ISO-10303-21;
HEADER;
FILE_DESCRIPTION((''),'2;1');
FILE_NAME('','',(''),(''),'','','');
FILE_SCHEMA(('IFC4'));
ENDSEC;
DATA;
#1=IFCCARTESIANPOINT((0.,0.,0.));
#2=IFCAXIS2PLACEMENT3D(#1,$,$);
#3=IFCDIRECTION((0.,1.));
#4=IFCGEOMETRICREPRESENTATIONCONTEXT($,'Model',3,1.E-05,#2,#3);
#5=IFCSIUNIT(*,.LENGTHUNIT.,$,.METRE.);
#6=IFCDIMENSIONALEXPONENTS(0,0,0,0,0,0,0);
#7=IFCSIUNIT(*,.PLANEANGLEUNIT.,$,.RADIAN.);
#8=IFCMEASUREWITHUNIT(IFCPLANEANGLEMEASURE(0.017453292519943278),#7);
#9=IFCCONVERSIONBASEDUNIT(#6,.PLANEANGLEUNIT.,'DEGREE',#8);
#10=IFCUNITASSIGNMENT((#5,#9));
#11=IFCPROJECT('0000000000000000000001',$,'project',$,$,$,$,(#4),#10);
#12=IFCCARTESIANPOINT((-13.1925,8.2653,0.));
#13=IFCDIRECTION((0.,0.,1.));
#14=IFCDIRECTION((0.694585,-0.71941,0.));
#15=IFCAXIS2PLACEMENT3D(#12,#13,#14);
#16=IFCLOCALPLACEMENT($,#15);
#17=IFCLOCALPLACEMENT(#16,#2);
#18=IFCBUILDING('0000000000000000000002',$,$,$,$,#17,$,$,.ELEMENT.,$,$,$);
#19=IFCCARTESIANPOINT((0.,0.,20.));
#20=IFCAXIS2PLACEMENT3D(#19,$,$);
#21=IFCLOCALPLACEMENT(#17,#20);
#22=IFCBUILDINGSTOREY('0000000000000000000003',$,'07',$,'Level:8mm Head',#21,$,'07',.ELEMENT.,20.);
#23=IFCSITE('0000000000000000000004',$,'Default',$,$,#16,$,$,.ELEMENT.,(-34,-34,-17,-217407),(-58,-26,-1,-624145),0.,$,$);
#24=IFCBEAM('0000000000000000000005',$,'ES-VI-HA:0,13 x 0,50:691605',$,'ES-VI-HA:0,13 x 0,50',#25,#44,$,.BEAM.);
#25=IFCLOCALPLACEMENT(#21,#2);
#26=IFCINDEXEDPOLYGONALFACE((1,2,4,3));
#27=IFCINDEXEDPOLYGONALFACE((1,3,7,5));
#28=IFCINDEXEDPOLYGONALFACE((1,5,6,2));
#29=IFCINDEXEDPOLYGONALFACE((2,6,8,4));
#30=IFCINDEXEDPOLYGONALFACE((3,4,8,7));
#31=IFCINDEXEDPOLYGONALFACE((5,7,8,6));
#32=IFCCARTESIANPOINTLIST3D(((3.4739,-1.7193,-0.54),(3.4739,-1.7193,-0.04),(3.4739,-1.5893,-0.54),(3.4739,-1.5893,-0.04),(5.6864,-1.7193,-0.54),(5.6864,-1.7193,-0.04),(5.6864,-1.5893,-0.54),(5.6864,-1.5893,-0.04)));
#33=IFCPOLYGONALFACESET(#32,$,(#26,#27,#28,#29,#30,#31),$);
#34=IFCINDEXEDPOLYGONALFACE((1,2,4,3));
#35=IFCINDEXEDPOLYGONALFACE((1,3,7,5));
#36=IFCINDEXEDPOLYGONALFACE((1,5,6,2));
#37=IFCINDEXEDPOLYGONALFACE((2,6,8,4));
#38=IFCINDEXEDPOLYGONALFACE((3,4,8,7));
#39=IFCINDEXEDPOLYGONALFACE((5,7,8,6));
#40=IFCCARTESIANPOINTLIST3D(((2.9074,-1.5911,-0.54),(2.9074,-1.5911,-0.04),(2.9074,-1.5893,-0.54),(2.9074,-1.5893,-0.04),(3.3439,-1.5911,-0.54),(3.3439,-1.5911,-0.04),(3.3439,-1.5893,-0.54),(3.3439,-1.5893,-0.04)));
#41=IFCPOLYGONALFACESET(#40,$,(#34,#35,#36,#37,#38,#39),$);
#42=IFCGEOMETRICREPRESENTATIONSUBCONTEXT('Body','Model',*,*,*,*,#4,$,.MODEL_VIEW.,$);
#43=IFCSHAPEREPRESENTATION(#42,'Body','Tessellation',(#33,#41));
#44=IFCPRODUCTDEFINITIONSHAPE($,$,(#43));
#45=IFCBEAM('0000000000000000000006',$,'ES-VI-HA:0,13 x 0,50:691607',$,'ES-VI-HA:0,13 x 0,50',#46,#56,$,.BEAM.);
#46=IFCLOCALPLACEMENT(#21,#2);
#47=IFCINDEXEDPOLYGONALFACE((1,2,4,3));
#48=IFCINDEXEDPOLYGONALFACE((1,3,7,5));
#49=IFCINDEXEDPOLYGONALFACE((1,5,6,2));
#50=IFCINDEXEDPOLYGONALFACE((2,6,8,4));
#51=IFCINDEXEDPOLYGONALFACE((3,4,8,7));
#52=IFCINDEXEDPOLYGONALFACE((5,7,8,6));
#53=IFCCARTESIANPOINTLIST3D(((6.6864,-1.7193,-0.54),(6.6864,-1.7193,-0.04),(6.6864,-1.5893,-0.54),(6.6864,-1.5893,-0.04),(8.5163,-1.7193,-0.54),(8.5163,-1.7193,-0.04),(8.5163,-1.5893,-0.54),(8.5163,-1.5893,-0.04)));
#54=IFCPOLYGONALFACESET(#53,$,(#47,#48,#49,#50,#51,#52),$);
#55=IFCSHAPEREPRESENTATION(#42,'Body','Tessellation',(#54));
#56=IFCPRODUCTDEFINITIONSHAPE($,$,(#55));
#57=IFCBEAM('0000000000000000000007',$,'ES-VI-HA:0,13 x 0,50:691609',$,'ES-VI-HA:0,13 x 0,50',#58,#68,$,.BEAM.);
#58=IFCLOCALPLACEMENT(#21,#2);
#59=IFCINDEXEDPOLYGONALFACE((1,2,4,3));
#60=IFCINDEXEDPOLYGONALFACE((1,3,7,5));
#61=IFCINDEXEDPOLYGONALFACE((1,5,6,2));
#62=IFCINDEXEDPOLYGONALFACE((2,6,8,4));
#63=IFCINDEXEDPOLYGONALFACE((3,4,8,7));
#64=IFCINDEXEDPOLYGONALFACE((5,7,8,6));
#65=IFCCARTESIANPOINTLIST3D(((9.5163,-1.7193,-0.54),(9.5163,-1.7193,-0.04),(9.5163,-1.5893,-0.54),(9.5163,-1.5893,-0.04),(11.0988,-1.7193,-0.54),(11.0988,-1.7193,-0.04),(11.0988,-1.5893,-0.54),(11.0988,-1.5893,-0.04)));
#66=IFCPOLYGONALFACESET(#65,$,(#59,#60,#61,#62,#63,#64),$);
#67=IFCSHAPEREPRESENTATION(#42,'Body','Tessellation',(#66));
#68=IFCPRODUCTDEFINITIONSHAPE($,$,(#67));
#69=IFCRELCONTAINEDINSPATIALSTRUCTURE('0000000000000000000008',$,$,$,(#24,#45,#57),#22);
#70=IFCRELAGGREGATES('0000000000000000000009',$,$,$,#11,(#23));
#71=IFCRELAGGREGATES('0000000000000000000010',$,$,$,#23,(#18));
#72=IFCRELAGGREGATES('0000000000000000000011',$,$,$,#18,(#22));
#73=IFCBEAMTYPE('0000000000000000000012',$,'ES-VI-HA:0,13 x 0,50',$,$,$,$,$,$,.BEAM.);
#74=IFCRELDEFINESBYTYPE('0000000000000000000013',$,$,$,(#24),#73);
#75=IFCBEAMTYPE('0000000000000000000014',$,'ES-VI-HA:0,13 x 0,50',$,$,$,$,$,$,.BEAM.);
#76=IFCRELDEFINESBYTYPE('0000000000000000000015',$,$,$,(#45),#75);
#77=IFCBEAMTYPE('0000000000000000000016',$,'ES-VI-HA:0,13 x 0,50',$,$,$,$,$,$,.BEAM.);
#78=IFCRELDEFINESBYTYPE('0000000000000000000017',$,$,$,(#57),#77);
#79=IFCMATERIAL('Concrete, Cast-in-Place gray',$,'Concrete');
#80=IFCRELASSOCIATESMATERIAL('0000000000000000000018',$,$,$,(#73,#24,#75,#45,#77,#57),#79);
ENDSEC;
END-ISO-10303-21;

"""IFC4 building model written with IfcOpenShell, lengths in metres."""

from ifc_helpers import new_model, entity, si_unit, converted_unit, direction, frame, origin, place, context, subcontext, project, spatial, indexed_curve, outline, extrude, source, transform, mapped, material, type_object, type_shapes, element, save


model = new_model("IFC4")

# Units and contexts
model_context = context("Model", 3, precision=1e-05, world=origin(), true_north=direction((0.0, 1.0)))
body_context = subcontext(model_context, "Body", "Model", "MODEL_VIEW")
ifc_project = project(units=[si_unit("LENGTHUNIT", "METRE"), converted_unit("PLANEANGLEUNIT", "DEGREE", entity("IfcPlaneAngleMeasure", 0.017453292519943278), si_unit("PLANEANGLEUNIT", "RADIAN"), dimensions=[0, 0, 0, 0, 0, 0, 0])], contexts=[model_context])

# Site, building, storey
site_placement = place(None, frame((-13.1925, 8.2653, 0.0), z_axis=(0.0, 0.0, 1.0), x_axis=(0.694585, -0.71941, 0.0)))
site = spatial("IfcSite", under=ifc_project, at=site_placement, Name="Default", CompositionType="ELEMENT", RefLatitude=(-34, -34, -17, -217407), RefLongitude=(-58, -26, -1, -624145), RefElevation=0.0)
building_placement = place(site_placement, origin())
building = spatial("IfcBuilding", under=site, at=building_placement, CompositionType="ELEMENT")
storey_placement = place(building_placement, frame((0.0, 0.0, 20.0)))
storey = spatial("IfcBuildingStorey", under=building, at=storey_placement, Name="07", ObjectType="Level:8mm Head", LongName="07", CompositionType="ELEMENT", Elevation=20.0)

# Beams
ifc_material_1 = material(Name="Concrete, Cast-in-Place gray", Category="Concrete")
beam_type_1 = type_object("IfcBeamType", Name="ES-VI-HA:0,13 x 0,50", PredefinedType="BEAM", material=ifc_material_1)
shared_shape_1 = source(origin(), body_context, "Body", "SweptSolid", [
    extrude(outline(indexed_curve([(-0.25, -0.065), (0.25, -0.065), (0.25, 0.065), (-0.25, 0.065), (-0.25, -0.065)], self_intersect=False)), frame((3.4739, -1.6543, 19.71), z_axis=(1.0, 0.0, 0.0), x_axis=(0.0, 0.0, -1.0)), (0.0, 0.0, 1.0), 2.2125),
    extrude(outline(indexed_curve([(-0.25, -0.0009), (0.25, -0.0009), (0.25, 0.0009), (-0.25, 0.0009), (-0.25, -0.0009)], self_intersect=False)), frame((2.9074, -1.5902, 19.71), z_axis=(1.0, 0.0, 0.0), x_axis=(0.0, 0.0, -1.0)), (0.0, 0.0, 1.0), 0.4365),
])
type_shapes(beam_type_1, [shared_shape_1])
beam_1_placement = place(storey_placement, frame((0.0, 0.0, -20.0)))
element("IfcBeam", 1, at=beam_1_placement, inside=storey, type_object=beam_type_1, material=ifc_material_1, Name="ES-VI-HA:0,13 x 0,50:691605", ObjectType="ES-VI-HA:0,13 x 0,50", PredefinedType="BEAM", context=body_context, shape_type="MappedRepresentation", body=[
    mapped(shared_shape_1, transform((0.0, 0.0, 0.0), scale=1.0)),
])
beam_type_2 = type_object("IfcBeamType", Name="ES-VI-HA:0,13 x 0,50", PredefinedType="BEAM", material=ifc_material_1)
shared_shape_2 = source(origin(), body_context, "Body", "SweptSolid", [
    extrude(outline(indexed_curve([(-0.25, -0.065), (0.25, -0.065), (0.25, 0.065), (-0.25, 0.065), (-0.25, -0.065)], self_intersect=False)), frame((6.6864, -1.6543, 19.71), z_axis=(1.0, 0.0, 0.0), x_axis=(0.0, 0.0, -1.0)), (0.0, 0.0, 1.0), 1.8299),
])
type_shapes(beam_type_2, [shared_shape_2])
beam_2_placement = place(storey_placement, frame((0.0, 0.0, -20.0)))
element("IfcBeam", 2, at=beam_2_placement, inside=storey, type_object=beam_type_2, material=ifc_material_1, Name="ES-VI-HA:0,13 x 0,50:691607", ObjectType="ES-VI-HA:0,13 x 0,50", PredefinedType="BEAM", context=body_context, shape_type="MappedRepresentation", body=[
    mapped(shared_shape_2, transform((0.0, 0.0, 0.0), scale=1.0)),
])
beam_type_3 = type_object("IfcBeamType", Name="ES-VI-HA:0,13 x 0,50", PredefinedType="BEAM", material=ifc_material_1)
shared_shape_3 = source(origin(), body_context, "Body", "SweptSolid", [
    extrude(outline(indexed_curve([(-0.25, -0.065), (0.25, -0.065), (0.25, 0.065), (-0.25, 0.065), (-0.25, -0.065)], self_intersect=False)), frame((9.5163, -1.6543, 19.71), z_axis=(1.0, 0.0, 0.0), x_axis=(0.0, 0.0, -1.0)), (0.0, 0.0, 1.0), 1.5825),
])
type_shapes(beam_type_3, [shared_shape_3])
beam_3_placement = place(storey_placement, frame((0.0, 0.0, -20.0)))
element("IfcBeam", 3, at=beam_3_placement, inside=storey, type_object=beam_type_3, material=ifc_material_1, Name="ES-VI-HA:0,13 x 0,50:691609", ObjectType="ES-VI-HA:0,13 x 0,50", PredefinedType="BEAM", context=body_context, shape_type="MappedRepresentation", body=[
    mapped(shared_shape_3, transform((0.0, 0.0, 0.0), scale=1.0)),
])

save(model, "model.ifc")
